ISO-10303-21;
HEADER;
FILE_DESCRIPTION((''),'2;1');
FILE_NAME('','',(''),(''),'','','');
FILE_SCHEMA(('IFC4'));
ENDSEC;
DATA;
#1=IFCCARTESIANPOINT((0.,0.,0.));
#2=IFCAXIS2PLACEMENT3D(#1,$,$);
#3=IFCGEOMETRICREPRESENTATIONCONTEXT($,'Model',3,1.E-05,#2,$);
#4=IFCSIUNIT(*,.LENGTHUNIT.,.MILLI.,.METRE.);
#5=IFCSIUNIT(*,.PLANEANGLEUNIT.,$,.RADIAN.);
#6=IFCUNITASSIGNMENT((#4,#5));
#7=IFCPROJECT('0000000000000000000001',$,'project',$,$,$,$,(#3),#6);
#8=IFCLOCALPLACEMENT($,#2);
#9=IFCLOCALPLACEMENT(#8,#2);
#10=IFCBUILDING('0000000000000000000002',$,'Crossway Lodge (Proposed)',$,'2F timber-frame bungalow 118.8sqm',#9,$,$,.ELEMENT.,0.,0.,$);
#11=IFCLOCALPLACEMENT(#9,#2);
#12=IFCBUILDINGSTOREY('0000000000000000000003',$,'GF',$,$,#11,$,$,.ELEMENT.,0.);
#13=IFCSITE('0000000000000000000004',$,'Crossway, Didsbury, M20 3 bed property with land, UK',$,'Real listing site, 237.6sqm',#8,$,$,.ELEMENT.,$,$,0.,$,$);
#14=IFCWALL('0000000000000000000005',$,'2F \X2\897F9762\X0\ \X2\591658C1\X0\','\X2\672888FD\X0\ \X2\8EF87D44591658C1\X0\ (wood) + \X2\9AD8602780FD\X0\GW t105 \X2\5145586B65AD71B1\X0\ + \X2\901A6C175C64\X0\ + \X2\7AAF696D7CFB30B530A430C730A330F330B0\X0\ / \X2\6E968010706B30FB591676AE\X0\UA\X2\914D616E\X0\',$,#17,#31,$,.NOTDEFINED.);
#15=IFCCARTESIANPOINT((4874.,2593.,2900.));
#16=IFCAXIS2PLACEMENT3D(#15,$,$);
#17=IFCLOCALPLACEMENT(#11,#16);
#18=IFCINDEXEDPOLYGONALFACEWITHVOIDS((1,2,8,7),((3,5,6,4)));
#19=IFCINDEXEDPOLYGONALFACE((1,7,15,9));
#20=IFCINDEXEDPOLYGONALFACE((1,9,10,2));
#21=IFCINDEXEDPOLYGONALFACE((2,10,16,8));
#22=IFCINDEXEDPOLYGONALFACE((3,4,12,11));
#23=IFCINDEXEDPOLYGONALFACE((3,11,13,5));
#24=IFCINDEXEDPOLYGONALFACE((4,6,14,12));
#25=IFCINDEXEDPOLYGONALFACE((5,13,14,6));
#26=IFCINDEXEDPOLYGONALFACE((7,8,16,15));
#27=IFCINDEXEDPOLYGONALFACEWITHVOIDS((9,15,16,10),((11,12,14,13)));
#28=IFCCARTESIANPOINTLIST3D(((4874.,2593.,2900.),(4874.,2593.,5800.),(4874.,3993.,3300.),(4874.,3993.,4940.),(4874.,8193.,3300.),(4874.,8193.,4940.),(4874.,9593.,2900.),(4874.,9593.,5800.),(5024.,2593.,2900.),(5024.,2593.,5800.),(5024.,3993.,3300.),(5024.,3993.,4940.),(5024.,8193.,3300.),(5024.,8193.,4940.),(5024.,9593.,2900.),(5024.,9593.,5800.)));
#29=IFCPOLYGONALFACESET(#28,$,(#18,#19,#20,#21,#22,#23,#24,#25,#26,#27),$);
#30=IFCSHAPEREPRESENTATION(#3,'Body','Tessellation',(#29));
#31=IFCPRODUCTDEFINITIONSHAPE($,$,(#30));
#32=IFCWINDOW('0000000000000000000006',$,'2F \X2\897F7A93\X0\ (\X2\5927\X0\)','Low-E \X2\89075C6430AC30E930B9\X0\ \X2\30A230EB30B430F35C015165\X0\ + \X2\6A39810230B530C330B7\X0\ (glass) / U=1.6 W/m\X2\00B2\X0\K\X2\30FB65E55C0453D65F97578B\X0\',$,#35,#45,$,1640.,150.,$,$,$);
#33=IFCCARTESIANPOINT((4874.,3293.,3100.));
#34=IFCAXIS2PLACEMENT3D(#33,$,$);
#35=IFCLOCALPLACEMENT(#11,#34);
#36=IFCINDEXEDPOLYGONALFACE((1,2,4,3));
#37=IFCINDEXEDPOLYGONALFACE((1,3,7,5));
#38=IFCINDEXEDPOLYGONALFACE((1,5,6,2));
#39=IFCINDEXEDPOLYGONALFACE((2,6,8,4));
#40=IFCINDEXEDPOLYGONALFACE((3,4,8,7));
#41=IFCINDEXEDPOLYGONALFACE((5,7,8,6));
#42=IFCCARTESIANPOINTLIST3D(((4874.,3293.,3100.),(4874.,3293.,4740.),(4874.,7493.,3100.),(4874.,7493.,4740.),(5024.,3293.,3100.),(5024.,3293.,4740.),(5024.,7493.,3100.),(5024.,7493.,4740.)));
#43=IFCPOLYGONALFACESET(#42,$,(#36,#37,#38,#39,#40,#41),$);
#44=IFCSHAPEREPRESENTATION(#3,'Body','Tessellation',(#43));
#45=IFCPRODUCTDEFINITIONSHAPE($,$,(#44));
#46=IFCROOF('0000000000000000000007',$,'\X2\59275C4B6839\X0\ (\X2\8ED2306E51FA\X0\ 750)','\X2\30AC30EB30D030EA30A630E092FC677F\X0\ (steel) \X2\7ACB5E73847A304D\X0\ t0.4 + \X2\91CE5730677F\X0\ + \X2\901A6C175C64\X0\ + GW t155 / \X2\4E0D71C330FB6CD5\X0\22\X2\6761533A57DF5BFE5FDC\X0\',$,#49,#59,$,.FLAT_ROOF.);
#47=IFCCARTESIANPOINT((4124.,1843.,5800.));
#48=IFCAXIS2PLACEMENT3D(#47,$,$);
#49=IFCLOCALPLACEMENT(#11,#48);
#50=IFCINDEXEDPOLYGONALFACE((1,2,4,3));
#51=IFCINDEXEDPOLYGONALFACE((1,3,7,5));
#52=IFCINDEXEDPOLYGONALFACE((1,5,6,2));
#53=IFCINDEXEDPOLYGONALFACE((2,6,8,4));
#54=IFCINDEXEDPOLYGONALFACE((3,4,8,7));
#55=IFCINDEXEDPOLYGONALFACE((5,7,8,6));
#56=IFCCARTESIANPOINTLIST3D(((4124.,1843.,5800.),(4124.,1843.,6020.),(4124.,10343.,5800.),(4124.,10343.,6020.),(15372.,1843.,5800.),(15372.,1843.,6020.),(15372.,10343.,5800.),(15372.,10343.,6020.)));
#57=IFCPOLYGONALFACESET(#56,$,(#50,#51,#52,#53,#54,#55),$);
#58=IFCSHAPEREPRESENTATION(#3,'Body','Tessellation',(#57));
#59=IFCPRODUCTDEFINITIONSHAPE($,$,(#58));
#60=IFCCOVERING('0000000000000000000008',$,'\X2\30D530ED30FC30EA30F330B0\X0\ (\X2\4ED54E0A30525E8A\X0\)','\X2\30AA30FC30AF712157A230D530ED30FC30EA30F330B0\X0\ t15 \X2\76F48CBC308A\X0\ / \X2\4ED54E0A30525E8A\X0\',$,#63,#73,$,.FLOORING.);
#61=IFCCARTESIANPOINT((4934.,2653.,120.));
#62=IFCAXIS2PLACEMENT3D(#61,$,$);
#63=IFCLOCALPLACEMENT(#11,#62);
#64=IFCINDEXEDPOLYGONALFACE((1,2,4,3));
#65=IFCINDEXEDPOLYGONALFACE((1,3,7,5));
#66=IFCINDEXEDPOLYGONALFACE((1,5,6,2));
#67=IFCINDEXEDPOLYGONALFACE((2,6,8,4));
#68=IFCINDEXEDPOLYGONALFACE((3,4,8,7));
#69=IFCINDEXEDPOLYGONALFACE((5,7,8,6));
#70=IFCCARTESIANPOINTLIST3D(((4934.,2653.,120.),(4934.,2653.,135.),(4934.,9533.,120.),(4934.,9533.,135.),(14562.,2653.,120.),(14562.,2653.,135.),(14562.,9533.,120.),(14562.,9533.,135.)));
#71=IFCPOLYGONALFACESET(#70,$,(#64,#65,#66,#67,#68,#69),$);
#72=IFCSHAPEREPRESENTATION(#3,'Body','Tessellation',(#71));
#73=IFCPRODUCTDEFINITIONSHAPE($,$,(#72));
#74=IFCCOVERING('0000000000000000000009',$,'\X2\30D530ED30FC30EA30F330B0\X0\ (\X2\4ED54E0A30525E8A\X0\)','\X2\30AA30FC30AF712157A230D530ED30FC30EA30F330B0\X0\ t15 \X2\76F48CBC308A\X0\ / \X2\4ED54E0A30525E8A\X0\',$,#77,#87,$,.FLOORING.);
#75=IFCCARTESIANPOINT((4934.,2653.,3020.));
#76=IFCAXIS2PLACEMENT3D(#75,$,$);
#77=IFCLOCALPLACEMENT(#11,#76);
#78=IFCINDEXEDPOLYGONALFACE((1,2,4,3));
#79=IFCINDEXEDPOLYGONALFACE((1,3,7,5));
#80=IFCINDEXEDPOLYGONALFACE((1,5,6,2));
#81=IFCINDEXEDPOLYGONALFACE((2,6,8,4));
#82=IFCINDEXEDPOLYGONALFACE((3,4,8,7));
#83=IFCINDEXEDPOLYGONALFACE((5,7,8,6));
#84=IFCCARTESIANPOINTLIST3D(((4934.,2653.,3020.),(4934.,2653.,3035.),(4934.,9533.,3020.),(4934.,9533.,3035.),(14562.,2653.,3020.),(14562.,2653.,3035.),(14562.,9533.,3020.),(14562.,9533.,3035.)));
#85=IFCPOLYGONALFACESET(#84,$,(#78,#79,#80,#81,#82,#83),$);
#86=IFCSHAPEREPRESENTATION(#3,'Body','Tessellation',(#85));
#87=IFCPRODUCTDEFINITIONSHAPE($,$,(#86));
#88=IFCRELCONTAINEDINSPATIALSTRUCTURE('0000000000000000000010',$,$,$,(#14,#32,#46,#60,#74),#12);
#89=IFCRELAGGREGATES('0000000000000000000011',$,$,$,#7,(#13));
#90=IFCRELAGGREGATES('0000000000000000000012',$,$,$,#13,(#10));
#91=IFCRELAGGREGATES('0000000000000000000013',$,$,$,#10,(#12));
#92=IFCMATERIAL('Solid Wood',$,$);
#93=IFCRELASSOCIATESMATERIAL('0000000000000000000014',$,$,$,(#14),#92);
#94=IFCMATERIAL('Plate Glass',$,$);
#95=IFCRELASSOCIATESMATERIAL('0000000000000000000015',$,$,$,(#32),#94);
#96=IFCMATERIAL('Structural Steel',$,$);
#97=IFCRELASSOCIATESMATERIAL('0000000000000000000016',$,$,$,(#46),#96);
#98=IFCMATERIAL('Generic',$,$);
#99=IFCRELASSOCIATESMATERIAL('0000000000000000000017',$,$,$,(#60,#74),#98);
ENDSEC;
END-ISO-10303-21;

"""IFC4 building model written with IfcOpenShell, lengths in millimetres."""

from ifc_helpers import new_model, si_unit, frame, frame_2d, origin, place, context, project, spatial, rectangle, extrude, material, element, fill, save


model = new_model("IFC4")

# Units and contexts
model_context = context("Model", 3, precision=1e-05, world=origin())
ifc_project = project(units=[si_unit("LENGTHUNIT", "METRE", prefix="MILLI"), si_unit("PLANEANGLEUNIT", "RADIAN")], contexts=[model_context])

# Site, building, storey
site_placement = place(None, origin())
site = spatial("IfcSite", under=ifc_project, at=site_placement, Name="Crossway, Didsbury, M20 3 bed property with land, UK", ObjectType="Real listing site, 237.6sqm", CompositionType="ELEMENT", RefElevation=0.0)
building_placement = place(site_placement, origin())
building = spatial("IfcBuilding", under=site, at=building_placement, Name="Crossway Lodge (Proposed)", ObjectType="2F timber-frame bungalow 118.8sqm", CompositionType="ELEMENT", ElevationOfRefHeight=0.0, ElevationOfTerrain=0.0)
storey_placement = place(building_placement, origin())
storey = spatial("IfcBuildingStorey", under=building, at=storey_placement, Name="GF", CompositionType="ELEMENT", Elevation=0.0)

# Shared definitions
ifc_material_1 = material(Name="Solid Wood")

# Shared definitions
ifc_material_2 = material(Name="Plate Glass")

# Wall, opening, window
wall_1_placement = place(storey_placement, frame((4874.0, 2593.0, 2900.0)))
wall_1 = element("IfcWall", 1, at=wall_1_placement, inside=storey, material=ifc_material_1, Name="2F 西面 外壁", Description="木製 軸組外壁 (wood) + 高性能GW t105 充填断熱 + 通気層 + 窯業系サイディング / 準耐火・外皮UA配慮", PredefinedType="NOTDEFINED", context=model_context, shape_type="SweptSolid", body=[
    extrude(rectangle(XDim=150.0, YDim=7000.0, at=frame_2d((75.0, 3500.0))), frame((4874.0, 2593.0, 2900.0)), (0.0, 0.0, 1.0), 2900.0),
])
opening_1_placement = place(storey_placement, frame((4874.0, 3293.0, 3100.0)))
opening_1 = element("IfcOpeningElement", 2, at=opening_1_placement, cuts=wall_1, PredefinedType="NOTDEFINED", context=model_context, shape_type="SweptSolid", body=[
    extrude(rectangle(XDim=150.0, YDim=4200.0, at=frame_2d((75.0, 2100.0))), frame((4874.0, 3293.0, 3100.0)), (0.0, 0.0, 1.0), 1640.0),
])
window_1_placement = place(storey_placement, frame((4874.0, 3293.0, 3100.0)))
window_1 = element("IfcWindow", 3, at=window_1_placement, inside=storey, material=ifc_material_2, Name="2F 西窓 (大)", Description="Low-E 複層ガラス アルゴン封入 + 樹脂サッシ (glass) / U=1.6 W/m²K・日射取得型", OverallHeight=1640.0, OverallWidth=150.0, context=model_context, shape_type="SweptSolid", body=[
    extrude(rectangle(XDim=150.0, YDim=4200.0, at=frame_2d((75.0, 2100.0))), frame((4874.0, 3293.0, 3100.0)), (0.0, 0.0, 1.0), 1640.0),
])
fill(opening_1, window_1)

# Roof
ifc_material_3 = material(Name="Structural Steel")
roof_placement = place(storey_placement, frame((4124.0, 1843.0, 5800.0)))
element("IfcRoof", 4, at=roof_placement, inside=storey, material=ifc_material_3, Name="大屋根 (軒の出 750)", Description="ガルバリウム鋼板 (steel) 立平葺き t0.4 + 野地板 + 通気層 + GW t155 / 不燃・法22条区域対応", PredefinedType="FLAT_ROOF", context=model_context, shape_type="SweptSolid", body=[
    extrude(rectangle(XDim=11248.0, YDim=8500.0, at=frame_2d((5624.0, 4250.0))), frame((4124.0, 1843.0, 5800.0)), (0.0, 0.0, 1.0), 220.0),
])

# Coverings
ifc_material_4 = material(Name="Generic")
covering_1_placement = place(storey_placement, frame((4934.0, 2653.0, 120.0)))
element("IfcCovering", 5, at=covering_1_placement, inside=storey, material=ifc_material_4, Name="フローリング (仕上げ床)", Description="オーク無垢フローリング t15 直貼り / 仕上げ床", PredefinedType="FLOORING", context=model_context, shape_type="SweptSolid", body=[
    extrude(rectangle(XDim=9628.0, YDim=6880.0, at=frame_2d((4814.0, 3440.0))), frame((4934.0, 2653.0, 120.0)), (0.0, 0.0, 1.0), 15.0),
])
covering_2_placement = place(storey_placement, frame((4934.0, 2653.0, 3020.0)))
element("IfcCovering", 6, at=covering_2_placement, inside=storey, material=ifc_material_4, Name="フローリング (仕上げ床)", Description="オーク無垢フローリング t15 直貼り / 仕上げ床", PredefinedType="FLOORING", context=model_context, shape_type="SweptSolid", body=[
    extrude(rectangle(XDim=9628.0, YDim=6880.0, at=frame_2d((4814.0, 3440.0))), frame((4934.0, 2653.0, 3020.0)), (0.0, 0.0, 1.0), 15.0),
])

save(model, "model.ifc")
